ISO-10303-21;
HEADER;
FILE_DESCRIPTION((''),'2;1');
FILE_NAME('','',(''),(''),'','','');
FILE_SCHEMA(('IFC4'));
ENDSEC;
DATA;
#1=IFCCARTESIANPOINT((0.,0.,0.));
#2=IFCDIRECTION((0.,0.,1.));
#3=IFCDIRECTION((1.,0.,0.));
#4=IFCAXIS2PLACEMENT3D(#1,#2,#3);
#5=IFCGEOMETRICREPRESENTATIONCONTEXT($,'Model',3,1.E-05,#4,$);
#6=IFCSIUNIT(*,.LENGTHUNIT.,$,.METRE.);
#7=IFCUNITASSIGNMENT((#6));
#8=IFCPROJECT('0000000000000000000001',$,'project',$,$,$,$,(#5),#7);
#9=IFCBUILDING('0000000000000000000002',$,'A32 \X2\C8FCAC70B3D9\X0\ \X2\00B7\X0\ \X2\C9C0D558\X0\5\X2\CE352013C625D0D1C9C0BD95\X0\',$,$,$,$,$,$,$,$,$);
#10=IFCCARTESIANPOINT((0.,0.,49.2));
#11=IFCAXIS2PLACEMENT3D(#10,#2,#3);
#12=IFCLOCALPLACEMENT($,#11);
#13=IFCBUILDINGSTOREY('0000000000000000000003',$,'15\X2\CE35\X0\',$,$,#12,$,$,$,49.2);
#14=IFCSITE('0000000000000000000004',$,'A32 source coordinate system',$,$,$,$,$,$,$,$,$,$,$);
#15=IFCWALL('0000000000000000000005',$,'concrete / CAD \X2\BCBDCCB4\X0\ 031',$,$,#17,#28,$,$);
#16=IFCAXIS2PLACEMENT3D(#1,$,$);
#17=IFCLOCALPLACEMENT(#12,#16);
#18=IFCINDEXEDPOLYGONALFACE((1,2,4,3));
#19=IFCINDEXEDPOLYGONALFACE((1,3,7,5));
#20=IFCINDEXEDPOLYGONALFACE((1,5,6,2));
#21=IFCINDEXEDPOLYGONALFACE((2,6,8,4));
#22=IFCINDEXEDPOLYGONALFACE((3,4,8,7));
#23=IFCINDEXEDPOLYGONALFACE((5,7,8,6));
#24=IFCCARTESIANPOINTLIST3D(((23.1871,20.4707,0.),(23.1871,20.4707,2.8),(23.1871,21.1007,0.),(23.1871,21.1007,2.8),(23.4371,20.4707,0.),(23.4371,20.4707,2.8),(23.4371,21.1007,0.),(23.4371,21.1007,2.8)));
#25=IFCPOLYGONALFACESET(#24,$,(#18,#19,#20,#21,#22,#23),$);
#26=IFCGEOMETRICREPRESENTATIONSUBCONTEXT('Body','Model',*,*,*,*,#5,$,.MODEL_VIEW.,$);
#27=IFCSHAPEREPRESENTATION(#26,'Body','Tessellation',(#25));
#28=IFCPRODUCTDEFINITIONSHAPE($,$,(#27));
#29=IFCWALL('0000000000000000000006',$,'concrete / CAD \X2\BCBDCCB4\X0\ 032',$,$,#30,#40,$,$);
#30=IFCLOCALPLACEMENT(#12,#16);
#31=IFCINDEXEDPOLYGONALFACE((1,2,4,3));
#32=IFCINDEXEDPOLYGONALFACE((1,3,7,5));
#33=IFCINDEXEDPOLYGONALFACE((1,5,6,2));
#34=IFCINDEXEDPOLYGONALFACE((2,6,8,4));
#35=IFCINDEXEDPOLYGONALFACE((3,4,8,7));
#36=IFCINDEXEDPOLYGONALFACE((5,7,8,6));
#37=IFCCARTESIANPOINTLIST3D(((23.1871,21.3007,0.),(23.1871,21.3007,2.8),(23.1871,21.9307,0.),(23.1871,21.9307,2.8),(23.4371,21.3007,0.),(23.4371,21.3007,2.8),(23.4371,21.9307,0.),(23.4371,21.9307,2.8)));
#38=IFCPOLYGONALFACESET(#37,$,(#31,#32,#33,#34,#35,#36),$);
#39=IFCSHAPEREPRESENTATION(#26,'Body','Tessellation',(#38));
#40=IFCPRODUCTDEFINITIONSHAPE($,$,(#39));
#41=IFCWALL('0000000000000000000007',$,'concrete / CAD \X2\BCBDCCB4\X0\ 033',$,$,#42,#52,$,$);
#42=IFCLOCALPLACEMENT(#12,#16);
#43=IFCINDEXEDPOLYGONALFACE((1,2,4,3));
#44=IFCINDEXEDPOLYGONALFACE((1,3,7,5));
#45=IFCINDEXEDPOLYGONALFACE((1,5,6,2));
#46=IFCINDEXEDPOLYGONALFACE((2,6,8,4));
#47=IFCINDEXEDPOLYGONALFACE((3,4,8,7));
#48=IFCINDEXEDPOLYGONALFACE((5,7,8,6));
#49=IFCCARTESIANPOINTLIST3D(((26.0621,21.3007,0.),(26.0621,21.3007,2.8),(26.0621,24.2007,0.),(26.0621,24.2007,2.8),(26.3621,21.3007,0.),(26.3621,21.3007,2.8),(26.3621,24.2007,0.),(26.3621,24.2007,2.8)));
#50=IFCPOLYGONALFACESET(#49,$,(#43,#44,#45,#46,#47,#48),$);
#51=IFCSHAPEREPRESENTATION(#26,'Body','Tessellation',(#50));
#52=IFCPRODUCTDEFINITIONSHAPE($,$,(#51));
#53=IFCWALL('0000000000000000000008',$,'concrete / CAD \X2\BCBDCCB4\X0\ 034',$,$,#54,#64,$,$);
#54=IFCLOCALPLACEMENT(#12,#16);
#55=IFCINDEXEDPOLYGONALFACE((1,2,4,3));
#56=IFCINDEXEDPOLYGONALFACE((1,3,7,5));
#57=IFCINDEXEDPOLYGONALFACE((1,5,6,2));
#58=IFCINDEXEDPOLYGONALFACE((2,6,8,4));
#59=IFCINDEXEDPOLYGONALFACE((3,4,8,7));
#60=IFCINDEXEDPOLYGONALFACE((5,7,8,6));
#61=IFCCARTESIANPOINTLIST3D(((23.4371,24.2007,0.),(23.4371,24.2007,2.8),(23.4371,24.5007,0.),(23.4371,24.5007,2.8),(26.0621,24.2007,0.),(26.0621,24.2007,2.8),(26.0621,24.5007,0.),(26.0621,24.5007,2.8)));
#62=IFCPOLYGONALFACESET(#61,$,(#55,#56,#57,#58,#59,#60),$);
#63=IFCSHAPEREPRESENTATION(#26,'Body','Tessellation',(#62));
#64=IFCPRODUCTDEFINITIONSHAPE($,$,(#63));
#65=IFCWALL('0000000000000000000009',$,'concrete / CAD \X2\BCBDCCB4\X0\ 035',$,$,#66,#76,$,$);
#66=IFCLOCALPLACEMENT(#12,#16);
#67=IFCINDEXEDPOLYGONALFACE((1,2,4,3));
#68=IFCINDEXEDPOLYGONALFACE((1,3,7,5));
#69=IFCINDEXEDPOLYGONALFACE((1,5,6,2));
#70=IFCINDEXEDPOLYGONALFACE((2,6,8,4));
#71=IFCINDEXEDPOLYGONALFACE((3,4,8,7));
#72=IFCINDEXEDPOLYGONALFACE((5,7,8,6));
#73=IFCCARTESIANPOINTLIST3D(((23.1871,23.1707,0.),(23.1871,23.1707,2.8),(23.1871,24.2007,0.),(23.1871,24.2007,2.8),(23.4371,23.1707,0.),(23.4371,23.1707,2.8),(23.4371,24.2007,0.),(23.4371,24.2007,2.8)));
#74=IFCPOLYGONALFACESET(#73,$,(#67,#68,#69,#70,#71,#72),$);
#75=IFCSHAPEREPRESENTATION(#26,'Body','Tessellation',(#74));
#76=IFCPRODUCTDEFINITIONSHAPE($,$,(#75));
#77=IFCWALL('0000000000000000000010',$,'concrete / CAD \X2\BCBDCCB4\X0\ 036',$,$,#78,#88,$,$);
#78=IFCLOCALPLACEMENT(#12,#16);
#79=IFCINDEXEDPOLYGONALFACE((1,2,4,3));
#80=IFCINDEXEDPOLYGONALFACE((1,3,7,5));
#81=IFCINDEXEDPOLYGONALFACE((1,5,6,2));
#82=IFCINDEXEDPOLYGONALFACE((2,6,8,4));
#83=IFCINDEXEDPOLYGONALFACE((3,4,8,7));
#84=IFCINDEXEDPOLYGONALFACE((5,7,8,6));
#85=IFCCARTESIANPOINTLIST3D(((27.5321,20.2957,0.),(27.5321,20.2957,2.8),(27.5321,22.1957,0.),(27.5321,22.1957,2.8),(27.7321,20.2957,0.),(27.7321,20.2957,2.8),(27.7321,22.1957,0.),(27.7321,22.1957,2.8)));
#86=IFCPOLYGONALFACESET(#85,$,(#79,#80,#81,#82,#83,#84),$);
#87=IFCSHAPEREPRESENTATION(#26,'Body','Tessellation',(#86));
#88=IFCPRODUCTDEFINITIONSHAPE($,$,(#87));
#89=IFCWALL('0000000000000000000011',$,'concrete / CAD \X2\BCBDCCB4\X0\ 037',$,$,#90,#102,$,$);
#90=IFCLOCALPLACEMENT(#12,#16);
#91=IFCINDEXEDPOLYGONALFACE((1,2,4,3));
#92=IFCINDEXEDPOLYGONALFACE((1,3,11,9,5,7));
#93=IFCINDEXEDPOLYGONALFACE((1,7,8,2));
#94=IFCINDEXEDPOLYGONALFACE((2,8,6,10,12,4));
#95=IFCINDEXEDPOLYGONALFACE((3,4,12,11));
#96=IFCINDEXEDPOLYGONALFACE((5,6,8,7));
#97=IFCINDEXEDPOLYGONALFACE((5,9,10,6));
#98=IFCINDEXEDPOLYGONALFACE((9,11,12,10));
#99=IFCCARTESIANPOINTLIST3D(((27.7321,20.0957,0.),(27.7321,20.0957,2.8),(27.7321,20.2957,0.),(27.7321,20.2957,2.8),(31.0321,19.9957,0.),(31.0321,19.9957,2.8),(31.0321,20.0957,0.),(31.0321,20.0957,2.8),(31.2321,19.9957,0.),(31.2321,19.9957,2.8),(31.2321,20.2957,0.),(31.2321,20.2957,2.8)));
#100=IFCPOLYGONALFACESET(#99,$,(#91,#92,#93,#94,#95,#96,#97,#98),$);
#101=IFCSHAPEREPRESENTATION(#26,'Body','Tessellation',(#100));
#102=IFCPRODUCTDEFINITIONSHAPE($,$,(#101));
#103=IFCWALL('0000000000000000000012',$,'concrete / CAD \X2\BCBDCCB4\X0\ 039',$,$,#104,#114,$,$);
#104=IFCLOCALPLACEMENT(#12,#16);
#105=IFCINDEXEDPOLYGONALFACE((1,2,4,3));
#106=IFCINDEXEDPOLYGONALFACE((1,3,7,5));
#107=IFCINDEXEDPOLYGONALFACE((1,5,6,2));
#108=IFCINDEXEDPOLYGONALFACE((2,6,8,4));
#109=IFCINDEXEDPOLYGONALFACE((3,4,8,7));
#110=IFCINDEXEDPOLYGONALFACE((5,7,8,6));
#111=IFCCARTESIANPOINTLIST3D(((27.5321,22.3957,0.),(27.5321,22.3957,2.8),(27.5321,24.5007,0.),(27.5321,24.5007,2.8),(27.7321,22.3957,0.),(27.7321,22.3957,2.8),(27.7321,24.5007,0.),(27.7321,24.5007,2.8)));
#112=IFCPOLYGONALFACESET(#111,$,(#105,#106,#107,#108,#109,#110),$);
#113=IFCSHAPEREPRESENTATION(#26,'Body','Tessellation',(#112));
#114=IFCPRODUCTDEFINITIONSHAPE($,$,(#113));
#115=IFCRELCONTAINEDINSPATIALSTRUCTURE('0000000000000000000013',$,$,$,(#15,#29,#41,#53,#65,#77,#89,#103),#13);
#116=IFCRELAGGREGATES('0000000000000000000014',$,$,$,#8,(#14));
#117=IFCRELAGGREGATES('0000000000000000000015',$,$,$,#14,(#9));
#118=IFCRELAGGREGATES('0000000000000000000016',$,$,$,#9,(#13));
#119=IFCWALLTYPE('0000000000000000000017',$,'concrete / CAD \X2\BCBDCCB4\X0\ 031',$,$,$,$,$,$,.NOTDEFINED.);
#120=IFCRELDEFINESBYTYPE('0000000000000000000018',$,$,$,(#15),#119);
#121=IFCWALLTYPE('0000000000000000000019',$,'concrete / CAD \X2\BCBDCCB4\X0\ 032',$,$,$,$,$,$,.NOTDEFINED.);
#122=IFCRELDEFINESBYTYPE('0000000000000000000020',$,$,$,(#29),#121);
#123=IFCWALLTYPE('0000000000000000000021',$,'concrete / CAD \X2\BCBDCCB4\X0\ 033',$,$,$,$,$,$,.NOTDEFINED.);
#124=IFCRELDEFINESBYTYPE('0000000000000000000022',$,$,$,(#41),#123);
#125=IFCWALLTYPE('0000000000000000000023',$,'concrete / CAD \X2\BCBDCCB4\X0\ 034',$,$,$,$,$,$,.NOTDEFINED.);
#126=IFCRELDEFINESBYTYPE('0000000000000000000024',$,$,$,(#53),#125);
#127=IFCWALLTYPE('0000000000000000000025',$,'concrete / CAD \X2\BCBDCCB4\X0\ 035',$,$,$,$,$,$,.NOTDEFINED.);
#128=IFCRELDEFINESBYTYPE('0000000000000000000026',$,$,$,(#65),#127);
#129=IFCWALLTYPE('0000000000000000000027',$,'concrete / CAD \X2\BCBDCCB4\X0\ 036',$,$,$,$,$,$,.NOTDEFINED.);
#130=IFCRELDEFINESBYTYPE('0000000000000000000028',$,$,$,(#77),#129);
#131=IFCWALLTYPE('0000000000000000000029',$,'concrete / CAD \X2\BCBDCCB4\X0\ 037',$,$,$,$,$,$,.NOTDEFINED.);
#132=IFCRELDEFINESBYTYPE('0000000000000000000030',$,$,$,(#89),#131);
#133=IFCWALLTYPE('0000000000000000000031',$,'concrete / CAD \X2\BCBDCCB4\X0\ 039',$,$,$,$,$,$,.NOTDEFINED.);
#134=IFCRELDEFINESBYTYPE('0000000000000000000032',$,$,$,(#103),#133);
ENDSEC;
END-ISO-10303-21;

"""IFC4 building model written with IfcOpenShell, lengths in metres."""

from ifc_helpers import new_model, si_unit, frame, origin, origin_with_axes, place, context, subcontext, project, spatial, polyline, outline, extrude, source, transform, mapped, type_object, type_shapes, element, save


model = new_model("IFC4")

# Units and contexts
model_context = context("Model", 3, precision=1e-05, world=origin_with_axes())
body_context = subcontext(model_context, "Body", "Model", "MODEL_VIEW")
ifc_project = project(units=[si_unit("LENGTHUNIT", "METRE")], contexts=[model_context])

# Site, building, storey
site = spatial("IfcSite", under=ifc_project, Name="A32 source coordinate system")
building = spatial("IfcBuilding", under=site, Name="A32 주거동 · 지하5층–옥탑지붕")
storey_placement = place(None, frame((0.0, 0.0, 49.2), z_axis=(0.0, 0.0, 1.0), x_axis=(1.0, 0.0, 0.0)))
storey = spatial("IfcBuildingStorey", under=building, at=storey_placement, Name="15층", Elevation=49.2)

# Walls
wall_type_1 = type_object("IfcWallType", Name="concrete / CAD 벽체 031", PredefinedType="NOTDEFINED")
shared_shape_1 = source(origin(), body_context, "Body", "SweptSolid", [
    extrude(outline(polyline([(23.1871, 20.4707), (23.1871, 21.1007), (23.4371, 21.1007), (23.4371, 20.4707), (23.1871, 20.4707)])), origin(), (0.0, 0.0, 1.0), 2.8),
])
type_shapes(wall_type_1, [shared_shape_1])
wall_1_placement = place(storey_placement, origin_with_axes())
element("IfcWall", 1, at=wall_1_placement, inside=storey, type_object=wall_type_1, Name="concrete / CAD 벽체 031", context=body_context, shape_type="MappedRepresentation", body=[
    mapped(shared_shape_1, transform((0.0, 0.0, 0.0), scale=1.0)),
])
wall_type_2 = type_object("IfcWallType", Name="concrete / CAD 벽체 032", PredefinedType="NOTDEFINED")
shared_shape_2 = source(origin(), body_context, "Body", "SweptSolid", [
    extrude(outline(polyline([(23.4371, 21.9307), (23.4371, 21.3007), (23.1871, 21.3007), (23.1871, 21.9307), (23.4371, 21.9307)])), origin(), (0.0, 0.0, 1.0), 2.8),
])
type_shapes(wall_type_2, [shared_shape_2])
wall_2_placement = place(storey_placement, origin_with_axes())
element("IfcWall", 2, at=wall_2_placement, inside=storey, type_object=wall_type_2, Name="concrete / CAD 벽체 032", context=body_context, shape_type="MappedRepresentation", body=[
    mapped(shared_shape_2, transform((0.0, 0.0, 0.0), scale=1.0)),
])
wall_type_3 = type_object("IfcWallType", Name="concrete / CAD 벽체 033", PredefinedType="NOTDEFINED")
shared_shape_3 = source(origin(), body_context, "Body", "SweptSolid", [
    extrude(outline(polyline([(26.3621, 24.2007), (26.3621, 21.3007), (26.0621, 21.3007), (26.0621, 24.2007), (26.3621, 24.2007)])), origin(), (0.0, 0.0, 1.0), 2.8),
])
type_shapes(wall_type_3, [shared_shape_3])
wall_3_placement = place(storey_placement, origin_with_axes())
element("IfcWall", 3, at=wall_3_placement, inside=storey, type_object=wall_type_3, Name="concrete / CAD 벽체 033", context=body_context, shape_type="MappedRepresentation", body=[
    mapped(shared_shape_3, transform((0.0, 0.0, 0.0), scale=1.0)),
])
wall_type_4 = type_object("IfcWallType", Name="concrete / CAD 벽체 034", PredefinedType="NOTDEFINED")
shared_shape_4 = source(origin(), body_context, "Body", "SweptSolid", [
    extrude(outline(polyline([(23.4371, 24.5007), (26.0621, 24.5007), (26.0621, 24.2007), (23.4371, 24.2007), (23.4371, 24.5007)])), origin(), (0.0, 0.0, 1.0), 2.8),
])
type_shapes(wall_type_4, [shared_shape_4])
wall_4_placement = place(storey_placement, origin_with_axes())
element("IfcWall", 4, at=wall_4_placement, inside=storey, type_object=wall_type_4, Name="concrete / CAD 벽체 034", context=body_context, shape_type="MappedRepresentation", body=[
    mapped(shared_shape_4, transform((0.0, 0.0, 0.0), scale=1.0)),
])
wall_type_5 = type_object("IfcWallType", Name="concrete / CAD 벽체 035", PredefinedType="NOTDEFINED")
shared_shape_5 = source(origin(), body_context, "Body", "SweptSolid", [
    extrude(outline(polyline([(23.1871, 23.1707), (23.1871, 24.2007), (23.4371, 24.2007), (23.4371, 23.1707), (23.1871, 23.1707)])), origin(), (0.0, 0.0, 1.0), 2.8),
])
type_shapes(wall_type_5, [shared_shape_5])
wall_5_placement = place(storey_placement, origin_with_axes())
element("IfcWall", 5, at=wall_5_placement, inside=storey, type_object=wall_type_5, Name="concrete / CAD 벽체 035", context=body_context, shape_type="MappedRepresentation", body=[
    mapped(shared_shape_5, transform((0.0, 0.0, 0.0), scale=1.0)),
])
wall_type_6 = type_object("IfcWallType", Name="concrete / CAD 벽체 036", PredefinedType="NOTDEFINED")
shared_shape_6 = source(origin(), body_context, "Body", "SweptSolid", [
    extrude(outline(polyline([(27.7321, 22.1957), (27.7321, 20.2957), (27.5321, 20.2957), (27.5321, 22.1957), (27.7321, 22.1957)])), origin(), (0.0, 0.0, 1.0), 2.8),
])
type_shapes(wall_type_6, [shared_shape_6])
wall_6_placement = place(storey_placement, origin_with_axes())
element("IfcWall", 6, at=wall_6_placement, inside=storey, type_object=wall_type_6, Name="concrete / CAD 벽체 036", context=body_context, shape_type="MappedRepresentation", body=[
    mapped(shared_shape_6, transform((0.0, 0.0, 0.0), scale=1.0)),
])
wall_type_7 = type_object("IfcWallType", Name="concrete / CAD 벽체 037", PredefinedType="NOTDEFINED")
shared_shape_7 = source(origin(), body_context, "Body", "SweptSolid", [
    extrude(outline(polyline([(31.2321, 19.9957), (31.0321, 19.9957), (31.0321, 20.0957), (27.7321, 20.0957), (27.7321, 20.2957), (31.2321, 20.2957), (31.2321, 19.9957)])), origin(), (0.0, 0.0, 1.0), 2.8),
])
type_shapes(wall_type_7, [shared_shape_7])
wall_7_placement = place(storey_placement, origin_with_axes())
element("IfcWall", 7, at=wall_7_placement, inside=storey, type_object=wall_type_7, Name="concrete / CAD 벽체 037", context=body_context, shape_type="MappedRepresentation", body=[
    mapped(shared_shape_7, transform((0.0, 0.0, 0.0), scale=1.0)),
])
wall_type_8 = type_object("IfcWallType", Name="concrete / CAD 벽체 039", PredefinedType="NOTDEFINED")
shared_shape_8 = source(origin(), body_context, "Body", "SweptSolid", [
    extrude(outline(polyline([(27.7321, 24.5007), (27.7321, 22.3957), (27.5321, 22.3957), (27.5321, 24.5007), (27.7321, 24.5007)])), origin(), (0.0, 0.0, 1.0), 2.8),
])
type_shapes(wall_type_8, [shared_shape_8])
wall_8_placement = place(storey_placement, origin_with_axes())
element("IfcWall", 8, at=wall_8_placement, inside=storey, type_object=wall_type_8, Name="concrete / CAD 벽체 039", context=body_context, shape_type="MappedRepresentation", body=[
    mapped(shared_shape_8, transform((0.0, 0.0, 0.0), scale=1.0)),
])

save(model, "model.ifc")
